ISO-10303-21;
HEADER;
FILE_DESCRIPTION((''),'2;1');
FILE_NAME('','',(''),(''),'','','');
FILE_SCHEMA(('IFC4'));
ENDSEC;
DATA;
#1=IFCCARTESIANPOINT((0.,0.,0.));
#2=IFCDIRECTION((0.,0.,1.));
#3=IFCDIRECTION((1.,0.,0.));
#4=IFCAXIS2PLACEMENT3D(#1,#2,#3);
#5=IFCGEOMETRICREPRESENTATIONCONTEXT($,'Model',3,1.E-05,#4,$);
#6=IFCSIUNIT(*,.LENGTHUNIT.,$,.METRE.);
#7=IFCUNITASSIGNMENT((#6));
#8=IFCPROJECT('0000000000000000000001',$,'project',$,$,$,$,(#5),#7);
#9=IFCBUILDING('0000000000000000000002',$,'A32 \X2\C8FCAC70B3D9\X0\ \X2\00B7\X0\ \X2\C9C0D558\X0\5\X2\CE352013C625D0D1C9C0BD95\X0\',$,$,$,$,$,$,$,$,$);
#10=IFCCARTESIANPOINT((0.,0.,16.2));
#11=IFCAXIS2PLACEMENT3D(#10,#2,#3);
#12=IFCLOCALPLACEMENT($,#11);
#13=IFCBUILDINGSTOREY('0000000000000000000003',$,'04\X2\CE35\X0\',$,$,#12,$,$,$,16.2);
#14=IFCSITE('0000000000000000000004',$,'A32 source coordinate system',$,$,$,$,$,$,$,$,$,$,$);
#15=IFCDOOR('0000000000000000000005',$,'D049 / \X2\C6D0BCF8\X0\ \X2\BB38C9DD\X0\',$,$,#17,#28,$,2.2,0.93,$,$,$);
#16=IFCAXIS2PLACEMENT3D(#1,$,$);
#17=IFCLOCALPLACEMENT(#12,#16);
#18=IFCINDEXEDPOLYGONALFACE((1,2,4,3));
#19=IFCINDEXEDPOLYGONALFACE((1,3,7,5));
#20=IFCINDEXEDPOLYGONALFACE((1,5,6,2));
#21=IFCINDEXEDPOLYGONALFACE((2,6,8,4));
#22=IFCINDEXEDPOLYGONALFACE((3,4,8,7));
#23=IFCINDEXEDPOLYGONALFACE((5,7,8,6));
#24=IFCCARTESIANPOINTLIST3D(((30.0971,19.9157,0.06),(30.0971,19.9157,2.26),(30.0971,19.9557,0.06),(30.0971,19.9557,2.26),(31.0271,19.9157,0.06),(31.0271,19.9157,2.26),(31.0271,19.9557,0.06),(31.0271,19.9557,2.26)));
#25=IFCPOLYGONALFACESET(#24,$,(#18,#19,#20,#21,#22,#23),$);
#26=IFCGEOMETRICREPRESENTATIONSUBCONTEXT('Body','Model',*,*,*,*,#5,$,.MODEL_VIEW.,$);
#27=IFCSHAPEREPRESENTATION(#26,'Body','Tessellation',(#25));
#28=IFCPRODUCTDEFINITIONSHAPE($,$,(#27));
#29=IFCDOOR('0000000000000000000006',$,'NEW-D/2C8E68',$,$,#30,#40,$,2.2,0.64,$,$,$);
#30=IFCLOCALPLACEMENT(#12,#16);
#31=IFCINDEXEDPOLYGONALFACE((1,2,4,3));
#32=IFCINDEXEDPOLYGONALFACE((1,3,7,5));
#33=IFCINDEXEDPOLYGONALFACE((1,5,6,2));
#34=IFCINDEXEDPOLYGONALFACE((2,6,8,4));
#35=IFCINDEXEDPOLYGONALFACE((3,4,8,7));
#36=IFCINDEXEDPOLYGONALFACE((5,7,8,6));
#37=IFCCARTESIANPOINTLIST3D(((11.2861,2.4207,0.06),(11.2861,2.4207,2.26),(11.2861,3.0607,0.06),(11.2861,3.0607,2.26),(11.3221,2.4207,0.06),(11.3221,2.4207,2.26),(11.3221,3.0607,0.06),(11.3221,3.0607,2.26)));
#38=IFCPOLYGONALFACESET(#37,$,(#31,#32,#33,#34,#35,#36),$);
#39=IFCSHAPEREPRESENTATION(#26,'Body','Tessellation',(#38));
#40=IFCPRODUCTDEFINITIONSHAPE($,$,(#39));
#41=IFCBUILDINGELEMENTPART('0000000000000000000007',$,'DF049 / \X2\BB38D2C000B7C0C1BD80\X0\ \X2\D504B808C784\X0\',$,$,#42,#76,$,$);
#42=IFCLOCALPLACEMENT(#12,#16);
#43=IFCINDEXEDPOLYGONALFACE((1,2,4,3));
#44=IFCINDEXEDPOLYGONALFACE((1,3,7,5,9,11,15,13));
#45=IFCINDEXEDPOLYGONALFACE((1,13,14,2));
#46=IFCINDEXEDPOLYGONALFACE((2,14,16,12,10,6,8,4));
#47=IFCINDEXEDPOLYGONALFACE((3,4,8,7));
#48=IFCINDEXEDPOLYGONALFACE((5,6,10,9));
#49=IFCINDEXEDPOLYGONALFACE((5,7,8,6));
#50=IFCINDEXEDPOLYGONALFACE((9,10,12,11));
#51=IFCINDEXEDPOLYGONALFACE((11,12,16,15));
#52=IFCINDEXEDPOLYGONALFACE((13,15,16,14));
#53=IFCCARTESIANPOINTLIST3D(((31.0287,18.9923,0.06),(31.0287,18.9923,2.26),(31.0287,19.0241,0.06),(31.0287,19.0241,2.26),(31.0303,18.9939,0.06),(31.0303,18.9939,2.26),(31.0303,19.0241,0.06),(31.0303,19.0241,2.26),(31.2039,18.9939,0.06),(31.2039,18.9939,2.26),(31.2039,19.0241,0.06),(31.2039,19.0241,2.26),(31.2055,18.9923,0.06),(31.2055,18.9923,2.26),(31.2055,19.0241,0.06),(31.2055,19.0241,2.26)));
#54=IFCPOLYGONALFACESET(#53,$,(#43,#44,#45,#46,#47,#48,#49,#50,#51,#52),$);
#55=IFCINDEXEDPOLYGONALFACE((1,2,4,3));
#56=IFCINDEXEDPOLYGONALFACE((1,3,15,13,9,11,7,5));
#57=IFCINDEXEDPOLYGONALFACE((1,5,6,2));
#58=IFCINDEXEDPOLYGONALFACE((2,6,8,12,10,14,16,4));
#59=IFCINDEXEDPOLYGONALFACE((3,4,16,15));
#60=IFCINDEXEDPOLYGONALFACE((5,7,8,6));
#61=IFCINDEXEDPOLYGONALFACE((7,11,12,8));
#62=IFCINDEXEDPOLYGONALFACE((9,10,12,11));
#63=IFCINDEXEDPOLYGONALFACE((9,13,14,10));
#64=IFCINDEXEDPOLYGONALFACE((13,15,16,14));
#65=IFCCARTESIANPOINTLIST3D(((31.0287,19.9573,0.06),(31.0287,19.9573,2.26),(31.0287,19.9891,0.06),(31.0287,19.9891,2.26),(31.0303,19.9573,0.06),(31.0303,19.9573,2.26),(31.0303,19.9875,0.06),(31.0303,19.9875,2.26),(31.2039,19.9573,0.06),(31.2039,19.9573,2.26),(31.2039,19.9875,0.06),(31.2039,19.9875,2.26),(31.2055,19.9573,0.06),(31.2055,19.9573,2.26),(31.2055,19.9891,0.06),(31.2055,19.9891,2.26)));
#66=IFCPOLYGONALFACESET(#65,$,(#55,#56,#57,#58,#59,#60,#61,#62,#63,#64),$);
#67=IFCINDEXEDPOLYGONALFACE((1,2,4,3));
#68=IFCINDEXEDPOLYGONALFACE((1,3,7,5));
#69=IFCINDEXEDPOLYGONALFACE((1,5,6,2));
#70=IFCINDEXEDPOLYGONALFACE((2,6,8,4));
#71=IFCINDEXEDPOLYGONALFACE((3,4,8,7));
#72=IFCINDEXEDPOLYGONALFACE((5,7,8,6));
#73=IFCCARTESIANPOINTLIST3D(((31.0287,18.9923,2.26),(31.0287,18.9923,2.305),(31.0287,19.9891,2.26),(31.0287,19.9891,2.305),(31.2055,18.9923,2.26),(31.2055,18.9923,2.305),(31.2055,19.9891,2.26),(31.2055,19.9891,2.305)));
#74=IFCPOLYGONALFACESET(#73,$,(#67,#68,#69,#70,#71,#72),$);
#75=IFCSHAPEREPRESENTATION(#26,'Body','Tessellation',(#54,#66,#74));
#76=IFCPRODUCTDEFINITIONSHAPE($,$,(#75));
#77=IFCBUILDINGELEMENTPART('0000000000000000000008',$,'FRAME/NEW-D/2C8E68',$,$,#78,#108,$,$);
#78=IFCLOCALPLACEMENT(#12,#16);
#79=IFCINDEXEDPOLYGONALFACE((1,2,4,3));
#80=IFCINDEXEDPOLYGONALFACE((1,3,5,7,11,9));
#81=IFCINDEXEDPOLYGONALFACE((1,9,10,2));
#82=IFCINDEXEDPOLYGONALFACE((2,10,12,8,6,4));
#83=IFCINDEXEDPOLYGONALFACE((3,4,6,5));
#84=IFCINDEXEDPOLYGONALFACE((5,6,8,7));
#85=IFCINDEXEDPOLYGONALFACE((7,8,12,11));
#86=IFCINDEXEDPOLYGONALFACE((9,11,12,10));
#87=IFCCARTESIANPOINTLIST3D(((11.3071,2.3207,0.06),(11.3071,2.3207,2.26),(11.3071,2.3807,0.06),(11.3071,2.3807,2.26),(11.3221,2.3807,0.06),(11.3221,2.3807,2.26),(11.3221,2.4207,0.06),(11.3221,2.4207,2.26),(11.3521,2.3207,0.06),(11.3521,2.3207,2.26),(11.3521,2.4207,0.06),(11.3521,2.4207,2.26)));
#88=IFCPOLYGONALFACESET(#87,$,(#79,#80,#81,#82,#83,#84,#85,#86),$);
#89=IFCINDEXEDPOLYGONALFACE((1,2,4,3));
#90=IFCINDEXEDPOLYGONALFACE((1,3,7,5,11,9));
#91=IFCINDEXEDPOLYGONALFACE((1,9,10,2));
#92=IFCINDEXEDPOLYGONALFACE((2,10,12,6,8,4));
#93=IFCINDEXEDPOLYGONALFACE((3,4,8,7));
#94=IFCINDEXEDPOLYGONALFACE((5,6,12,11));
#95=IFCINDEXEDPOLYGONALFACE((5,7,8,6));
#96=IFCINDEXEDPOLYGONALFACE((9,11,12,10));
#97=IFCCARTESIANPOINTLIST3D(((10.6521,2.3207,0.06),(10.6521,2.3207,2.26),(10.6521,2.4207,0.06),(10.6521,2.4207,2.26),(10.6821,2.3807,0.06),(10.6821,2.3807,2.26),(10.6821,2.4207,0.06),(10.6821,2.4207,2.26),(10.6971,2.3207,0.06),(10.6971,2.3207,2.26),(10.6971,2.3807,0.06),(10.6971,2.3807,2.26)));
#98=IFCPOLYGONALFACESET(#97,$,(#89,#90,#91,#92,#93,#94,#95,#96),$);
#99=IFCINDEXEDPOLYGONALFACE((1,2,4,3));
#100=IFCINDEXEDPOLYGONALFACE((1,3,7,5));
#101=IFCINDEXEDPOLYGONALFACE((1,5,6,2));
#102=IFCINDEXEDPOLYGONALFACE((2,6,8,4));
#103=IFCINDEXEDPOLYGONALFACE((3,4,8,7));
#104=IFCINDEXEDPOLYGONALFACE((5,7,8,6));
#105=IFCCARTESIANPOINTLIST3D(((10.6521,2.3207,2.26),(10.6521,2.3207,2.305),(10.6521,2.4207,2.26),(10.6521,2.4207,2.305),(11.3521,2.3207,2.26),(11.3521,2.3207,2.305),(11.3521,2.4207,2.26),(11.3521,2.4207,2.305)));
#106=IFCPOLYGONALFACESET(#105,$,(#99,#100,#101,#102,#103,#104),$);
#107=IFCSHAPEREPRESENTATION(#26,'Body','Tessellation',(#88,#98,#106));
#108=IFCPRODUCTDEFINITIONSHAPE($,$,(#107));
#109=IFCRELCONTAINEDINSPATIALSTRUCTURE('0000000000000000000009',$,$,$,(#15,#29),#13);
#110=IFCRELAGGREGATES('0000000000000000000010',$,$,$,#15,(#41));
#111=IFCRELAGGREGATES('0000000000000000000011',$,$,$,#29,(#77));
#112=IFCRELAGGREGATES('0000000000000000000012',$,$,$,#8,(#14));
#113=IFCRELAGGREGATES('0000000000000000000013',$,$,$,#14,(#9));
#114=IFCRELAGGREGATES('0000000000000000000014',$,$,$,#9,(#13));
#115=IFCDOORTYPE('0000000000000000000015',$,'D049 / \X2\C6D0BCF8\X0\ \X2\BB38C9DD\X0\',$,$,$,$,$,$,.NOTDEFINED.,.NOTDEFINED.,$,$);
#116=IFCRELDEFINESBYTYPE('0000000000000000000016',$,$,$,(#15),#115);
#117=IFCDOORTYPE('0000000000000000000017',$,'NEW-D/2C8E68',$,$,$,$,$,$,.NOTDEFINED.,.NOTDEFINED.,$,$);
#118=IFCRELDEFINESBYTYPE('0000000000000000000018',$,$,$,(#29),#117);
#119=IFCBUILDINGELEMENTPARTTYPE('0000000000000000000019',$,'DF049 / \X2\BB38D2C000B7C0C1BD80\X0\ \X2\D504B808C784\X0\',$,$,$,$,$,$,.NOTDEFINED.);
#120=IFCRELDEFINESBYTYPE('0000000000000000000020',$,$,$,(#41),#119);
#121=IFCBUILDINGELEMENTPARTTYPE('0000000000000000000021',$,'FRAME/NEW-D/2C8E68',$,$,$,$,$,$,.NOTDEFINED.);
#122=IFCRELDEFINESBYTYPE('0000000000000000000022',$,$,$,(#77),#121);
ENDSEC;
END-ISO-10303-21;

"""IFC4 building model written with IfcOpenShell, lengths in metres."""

from ifc_helpers import new_model, si_unit, frame, origin, origin_with_axes, place, context, subcontext, project, spatial, polyline, outline, extrude, source, transform, mapped, type_object, type_shapes, element, aggregate, save


model = new_model("IFC4")

# Units and contexts
model_context = context("Model", 3, precision=1e-05, world=origin_with_axes())
body_context = subcontext(model_context, "Body", "Model", "MODEL_VIEW")
ifc_project = project(units=[si_unit("LENGTHUNIT", "METRE")], contexts=[model_context])

# Site, building, storey
storey_placement = place(None, frame((0.0, 0.0, 16.2), z_axis=(0.0, 0.0, 1.0), x_axis=(1.0, 0.0, 0.0)))
site = spatial("IfcSite", under=ifc_project, Name="A32 source coordinate system")
building = spatial("IfcBuilding", under=site, Name="A32 주거동 · 지하5층–옥탑지붕")
storey = spatial("IfcBuildingStorey", under=building, at=storey_placement, Name="04층", Elevation=16.2)

# Doors
door_type_1 = type_object("IfcDoorType", Name="D049 / 원본 문짝", OperationType="NOTDEFINED", PredefinedType="NOTDEFINED")
shared_shape_1 = source(origin(), body_context, "Body", "SweptSolid", [
    extrude(outline(polyline([(31.0271, 19.9557), (31.0271, 19.9157), (30.0971, 19.9157), (30.0971, 19.9557), (31.0271, 19.9557)])), frame((0.0, 0.0, 0.06)), (0.0, 0.0, 1.0), 2.2),
])
type_shapes(door_type_1, [shared_shape_1])
door_1_placement = place(storey_placement, origin_with_axes())
door_1 = element("IfcDoor", 1, at=door_1_placement, inside=storey, type_object=door_type_1, Name="D049 / 원본 문짝", OverallHeight=2.2, OverallWidth=0.93, context=body_context, shape_type="MappedRepresentation", body=[
    mapped(shared_shape_1, transform((0.0, 0.0, 0.0), scale=1.0)),
])
door_type_2 = type_object("IfcDoorType", Name="NEW-D/2C8E68", OperationType="NOTDEFINED", PredefinedType="NOTDEFINED")
shared_shape_2 = source(origin(), body_context, "Body", "SweptSolid", [
    extrude(outline(polyline([(11.3221, 2.4207), (11.2861, 2.4207), (11.2861, 3.0607), (11.3221, 3.0607), (11.3221, 2.4207)])), frame((0.0, 0.0, 0.06)), (0.0, 0.0, 1.0), 2.2),
])
type_shapes(door_type_2, [shared_shape_2])
door_2_placement = place(storey_placement, origin_with_axes())
door_2 = element("IfcDoor", 2, at=door_2_placement, inside=storey, type_object=door_type_2, Name="NEW-D/2C8E68", OverallHeight=2.2, OverallWidth=0.64, context=body_context, shape_type="MappedRepresentation", body=[
    mapped(shared_shape_2, transform((0.0, 0.0, 0.0), scale=1.0)),
])

# Building element parts
building_element_part_type_1 = type_object("IfcBuildingElementPartType", Name="DF049 / 문틀·상부 프레임", PredefinedType="NOTDEFINED")
shared_shape_3 = source(origin(), body_context, "Body", "SweptSolid", [
    extrude(outline(polyline([(31.0303, 19.0241), (31.0303, 18.9939), (31.2039, 18.9939), (31.2039, 19.0241), (31.2055, 19.0241), (31.2055, 18.9923), (31.0287, 18.9923), (31.0287, 19.0241), (31.0303, 19.0241)])), frame((0.0, 0.0, 0.06)), (0.0, 0.0, 1.0), 2.2),
    extrude(outline(polyline([(31.0287, 19.9891), (31.2055, 19.9891), (31.2055, 19.9573), (31.2039, 19.9573), (31.2039, 19.9875), (31.0303, 19.9875), (31.0303, 19.9573), (31.0287, 19.9573), (31.0287, 19.9891)])), frame((0.0, 0.0, 0.06)), (0.0, 0.0, 1.0), 2.2),
    extrude(outline(polyline([(31.0287, 18.9923), (31.0287, 19.9891), (31.2055, 19.9891), (31.2055, 18.9923), (31.0287, 18.9923)])), frame((0.0, 0.0, 2.26)), (0.0, 0.0, 1.0), 0.045),
])
type_shapes(building_element_part_type_1, [shared_shape_3])
building_element_part_1_placement = place(door_1_placement, origin_with_axes())
building_element_part_1 = element("IfcBuildingElementPart", 3, at=building_element_part_1_placement, type_object=building_element_part_type_1, Name="DF049 / 문틀·상부 프레임", context=body_context, shape_type="MappedRepresentation", body=[
    mapped(shared_shape_3, transform((0.0, 0.0, 0.0), scale=1.0)),
])
aggregate(door_1, [building_element_part_1])
building_element_part_type_2 = type_object("IfcBuildingElementPartType", Name="FRAME/NEW-D/2C8E68", PredefinedType="NOTDEFINED")
shared_shape_4 = source(origin(), body_context, "Body", "SweptSolid", [
    extrude(outline(polyline([(11.3071, 2.3207), (11.3071, 2.3807), (11.3221, 2.3807), (11.3221, 2.4207), (11.3521, 2.4207), (11.3521, 2.3207), (11.3071, 2.3207)])), frame((0.0, 0.0, 0.06)), (0.0, 0.0, 1.0), 2.2),
    extrude(outline(polyline([(10.6821, 2.3807), (10.6971, 2.3807), (10.6971, 2.3207), (10.6521, 2.3207), (10.6521, 2.4207), (10.6821, 2.4207), (10.6821, 2.3807)])), frame((0.0, 0.0, 0.06)), (0.0, 0.0, 1.0), 2.2),
    extrude(outline(polyline([(11.3521, 2.3207), (11.3521, 2.4207), (10.6521, 2.4207), (10.6521, 2.3207), (11.3521, 2.3207)])), frame((0.0, 0.0, 2.26)), (0.0, 0.0, 1.0), 0.045),
])
type_shapes(building_element_part_type_2, [shared_shape_4])
building_element_part_2_placement = place(door_2_placement, origin_with_axes())
building_element_part_2 = element("IfcBuildingElementPart", 4, at=building_element_part_2_placement, type_object=building_element_part_type_2, Name="FRAME/NEW-D/2C8E68", context=body_context, shape_type="MappedRepresentation", body=[
    mapped(shared_shape_4, transform((0.0, 0.0, 0.0), scale=1.0)),
])
aggregate(door_2, [building_element_part_2])

save(model, "model.ifc")
